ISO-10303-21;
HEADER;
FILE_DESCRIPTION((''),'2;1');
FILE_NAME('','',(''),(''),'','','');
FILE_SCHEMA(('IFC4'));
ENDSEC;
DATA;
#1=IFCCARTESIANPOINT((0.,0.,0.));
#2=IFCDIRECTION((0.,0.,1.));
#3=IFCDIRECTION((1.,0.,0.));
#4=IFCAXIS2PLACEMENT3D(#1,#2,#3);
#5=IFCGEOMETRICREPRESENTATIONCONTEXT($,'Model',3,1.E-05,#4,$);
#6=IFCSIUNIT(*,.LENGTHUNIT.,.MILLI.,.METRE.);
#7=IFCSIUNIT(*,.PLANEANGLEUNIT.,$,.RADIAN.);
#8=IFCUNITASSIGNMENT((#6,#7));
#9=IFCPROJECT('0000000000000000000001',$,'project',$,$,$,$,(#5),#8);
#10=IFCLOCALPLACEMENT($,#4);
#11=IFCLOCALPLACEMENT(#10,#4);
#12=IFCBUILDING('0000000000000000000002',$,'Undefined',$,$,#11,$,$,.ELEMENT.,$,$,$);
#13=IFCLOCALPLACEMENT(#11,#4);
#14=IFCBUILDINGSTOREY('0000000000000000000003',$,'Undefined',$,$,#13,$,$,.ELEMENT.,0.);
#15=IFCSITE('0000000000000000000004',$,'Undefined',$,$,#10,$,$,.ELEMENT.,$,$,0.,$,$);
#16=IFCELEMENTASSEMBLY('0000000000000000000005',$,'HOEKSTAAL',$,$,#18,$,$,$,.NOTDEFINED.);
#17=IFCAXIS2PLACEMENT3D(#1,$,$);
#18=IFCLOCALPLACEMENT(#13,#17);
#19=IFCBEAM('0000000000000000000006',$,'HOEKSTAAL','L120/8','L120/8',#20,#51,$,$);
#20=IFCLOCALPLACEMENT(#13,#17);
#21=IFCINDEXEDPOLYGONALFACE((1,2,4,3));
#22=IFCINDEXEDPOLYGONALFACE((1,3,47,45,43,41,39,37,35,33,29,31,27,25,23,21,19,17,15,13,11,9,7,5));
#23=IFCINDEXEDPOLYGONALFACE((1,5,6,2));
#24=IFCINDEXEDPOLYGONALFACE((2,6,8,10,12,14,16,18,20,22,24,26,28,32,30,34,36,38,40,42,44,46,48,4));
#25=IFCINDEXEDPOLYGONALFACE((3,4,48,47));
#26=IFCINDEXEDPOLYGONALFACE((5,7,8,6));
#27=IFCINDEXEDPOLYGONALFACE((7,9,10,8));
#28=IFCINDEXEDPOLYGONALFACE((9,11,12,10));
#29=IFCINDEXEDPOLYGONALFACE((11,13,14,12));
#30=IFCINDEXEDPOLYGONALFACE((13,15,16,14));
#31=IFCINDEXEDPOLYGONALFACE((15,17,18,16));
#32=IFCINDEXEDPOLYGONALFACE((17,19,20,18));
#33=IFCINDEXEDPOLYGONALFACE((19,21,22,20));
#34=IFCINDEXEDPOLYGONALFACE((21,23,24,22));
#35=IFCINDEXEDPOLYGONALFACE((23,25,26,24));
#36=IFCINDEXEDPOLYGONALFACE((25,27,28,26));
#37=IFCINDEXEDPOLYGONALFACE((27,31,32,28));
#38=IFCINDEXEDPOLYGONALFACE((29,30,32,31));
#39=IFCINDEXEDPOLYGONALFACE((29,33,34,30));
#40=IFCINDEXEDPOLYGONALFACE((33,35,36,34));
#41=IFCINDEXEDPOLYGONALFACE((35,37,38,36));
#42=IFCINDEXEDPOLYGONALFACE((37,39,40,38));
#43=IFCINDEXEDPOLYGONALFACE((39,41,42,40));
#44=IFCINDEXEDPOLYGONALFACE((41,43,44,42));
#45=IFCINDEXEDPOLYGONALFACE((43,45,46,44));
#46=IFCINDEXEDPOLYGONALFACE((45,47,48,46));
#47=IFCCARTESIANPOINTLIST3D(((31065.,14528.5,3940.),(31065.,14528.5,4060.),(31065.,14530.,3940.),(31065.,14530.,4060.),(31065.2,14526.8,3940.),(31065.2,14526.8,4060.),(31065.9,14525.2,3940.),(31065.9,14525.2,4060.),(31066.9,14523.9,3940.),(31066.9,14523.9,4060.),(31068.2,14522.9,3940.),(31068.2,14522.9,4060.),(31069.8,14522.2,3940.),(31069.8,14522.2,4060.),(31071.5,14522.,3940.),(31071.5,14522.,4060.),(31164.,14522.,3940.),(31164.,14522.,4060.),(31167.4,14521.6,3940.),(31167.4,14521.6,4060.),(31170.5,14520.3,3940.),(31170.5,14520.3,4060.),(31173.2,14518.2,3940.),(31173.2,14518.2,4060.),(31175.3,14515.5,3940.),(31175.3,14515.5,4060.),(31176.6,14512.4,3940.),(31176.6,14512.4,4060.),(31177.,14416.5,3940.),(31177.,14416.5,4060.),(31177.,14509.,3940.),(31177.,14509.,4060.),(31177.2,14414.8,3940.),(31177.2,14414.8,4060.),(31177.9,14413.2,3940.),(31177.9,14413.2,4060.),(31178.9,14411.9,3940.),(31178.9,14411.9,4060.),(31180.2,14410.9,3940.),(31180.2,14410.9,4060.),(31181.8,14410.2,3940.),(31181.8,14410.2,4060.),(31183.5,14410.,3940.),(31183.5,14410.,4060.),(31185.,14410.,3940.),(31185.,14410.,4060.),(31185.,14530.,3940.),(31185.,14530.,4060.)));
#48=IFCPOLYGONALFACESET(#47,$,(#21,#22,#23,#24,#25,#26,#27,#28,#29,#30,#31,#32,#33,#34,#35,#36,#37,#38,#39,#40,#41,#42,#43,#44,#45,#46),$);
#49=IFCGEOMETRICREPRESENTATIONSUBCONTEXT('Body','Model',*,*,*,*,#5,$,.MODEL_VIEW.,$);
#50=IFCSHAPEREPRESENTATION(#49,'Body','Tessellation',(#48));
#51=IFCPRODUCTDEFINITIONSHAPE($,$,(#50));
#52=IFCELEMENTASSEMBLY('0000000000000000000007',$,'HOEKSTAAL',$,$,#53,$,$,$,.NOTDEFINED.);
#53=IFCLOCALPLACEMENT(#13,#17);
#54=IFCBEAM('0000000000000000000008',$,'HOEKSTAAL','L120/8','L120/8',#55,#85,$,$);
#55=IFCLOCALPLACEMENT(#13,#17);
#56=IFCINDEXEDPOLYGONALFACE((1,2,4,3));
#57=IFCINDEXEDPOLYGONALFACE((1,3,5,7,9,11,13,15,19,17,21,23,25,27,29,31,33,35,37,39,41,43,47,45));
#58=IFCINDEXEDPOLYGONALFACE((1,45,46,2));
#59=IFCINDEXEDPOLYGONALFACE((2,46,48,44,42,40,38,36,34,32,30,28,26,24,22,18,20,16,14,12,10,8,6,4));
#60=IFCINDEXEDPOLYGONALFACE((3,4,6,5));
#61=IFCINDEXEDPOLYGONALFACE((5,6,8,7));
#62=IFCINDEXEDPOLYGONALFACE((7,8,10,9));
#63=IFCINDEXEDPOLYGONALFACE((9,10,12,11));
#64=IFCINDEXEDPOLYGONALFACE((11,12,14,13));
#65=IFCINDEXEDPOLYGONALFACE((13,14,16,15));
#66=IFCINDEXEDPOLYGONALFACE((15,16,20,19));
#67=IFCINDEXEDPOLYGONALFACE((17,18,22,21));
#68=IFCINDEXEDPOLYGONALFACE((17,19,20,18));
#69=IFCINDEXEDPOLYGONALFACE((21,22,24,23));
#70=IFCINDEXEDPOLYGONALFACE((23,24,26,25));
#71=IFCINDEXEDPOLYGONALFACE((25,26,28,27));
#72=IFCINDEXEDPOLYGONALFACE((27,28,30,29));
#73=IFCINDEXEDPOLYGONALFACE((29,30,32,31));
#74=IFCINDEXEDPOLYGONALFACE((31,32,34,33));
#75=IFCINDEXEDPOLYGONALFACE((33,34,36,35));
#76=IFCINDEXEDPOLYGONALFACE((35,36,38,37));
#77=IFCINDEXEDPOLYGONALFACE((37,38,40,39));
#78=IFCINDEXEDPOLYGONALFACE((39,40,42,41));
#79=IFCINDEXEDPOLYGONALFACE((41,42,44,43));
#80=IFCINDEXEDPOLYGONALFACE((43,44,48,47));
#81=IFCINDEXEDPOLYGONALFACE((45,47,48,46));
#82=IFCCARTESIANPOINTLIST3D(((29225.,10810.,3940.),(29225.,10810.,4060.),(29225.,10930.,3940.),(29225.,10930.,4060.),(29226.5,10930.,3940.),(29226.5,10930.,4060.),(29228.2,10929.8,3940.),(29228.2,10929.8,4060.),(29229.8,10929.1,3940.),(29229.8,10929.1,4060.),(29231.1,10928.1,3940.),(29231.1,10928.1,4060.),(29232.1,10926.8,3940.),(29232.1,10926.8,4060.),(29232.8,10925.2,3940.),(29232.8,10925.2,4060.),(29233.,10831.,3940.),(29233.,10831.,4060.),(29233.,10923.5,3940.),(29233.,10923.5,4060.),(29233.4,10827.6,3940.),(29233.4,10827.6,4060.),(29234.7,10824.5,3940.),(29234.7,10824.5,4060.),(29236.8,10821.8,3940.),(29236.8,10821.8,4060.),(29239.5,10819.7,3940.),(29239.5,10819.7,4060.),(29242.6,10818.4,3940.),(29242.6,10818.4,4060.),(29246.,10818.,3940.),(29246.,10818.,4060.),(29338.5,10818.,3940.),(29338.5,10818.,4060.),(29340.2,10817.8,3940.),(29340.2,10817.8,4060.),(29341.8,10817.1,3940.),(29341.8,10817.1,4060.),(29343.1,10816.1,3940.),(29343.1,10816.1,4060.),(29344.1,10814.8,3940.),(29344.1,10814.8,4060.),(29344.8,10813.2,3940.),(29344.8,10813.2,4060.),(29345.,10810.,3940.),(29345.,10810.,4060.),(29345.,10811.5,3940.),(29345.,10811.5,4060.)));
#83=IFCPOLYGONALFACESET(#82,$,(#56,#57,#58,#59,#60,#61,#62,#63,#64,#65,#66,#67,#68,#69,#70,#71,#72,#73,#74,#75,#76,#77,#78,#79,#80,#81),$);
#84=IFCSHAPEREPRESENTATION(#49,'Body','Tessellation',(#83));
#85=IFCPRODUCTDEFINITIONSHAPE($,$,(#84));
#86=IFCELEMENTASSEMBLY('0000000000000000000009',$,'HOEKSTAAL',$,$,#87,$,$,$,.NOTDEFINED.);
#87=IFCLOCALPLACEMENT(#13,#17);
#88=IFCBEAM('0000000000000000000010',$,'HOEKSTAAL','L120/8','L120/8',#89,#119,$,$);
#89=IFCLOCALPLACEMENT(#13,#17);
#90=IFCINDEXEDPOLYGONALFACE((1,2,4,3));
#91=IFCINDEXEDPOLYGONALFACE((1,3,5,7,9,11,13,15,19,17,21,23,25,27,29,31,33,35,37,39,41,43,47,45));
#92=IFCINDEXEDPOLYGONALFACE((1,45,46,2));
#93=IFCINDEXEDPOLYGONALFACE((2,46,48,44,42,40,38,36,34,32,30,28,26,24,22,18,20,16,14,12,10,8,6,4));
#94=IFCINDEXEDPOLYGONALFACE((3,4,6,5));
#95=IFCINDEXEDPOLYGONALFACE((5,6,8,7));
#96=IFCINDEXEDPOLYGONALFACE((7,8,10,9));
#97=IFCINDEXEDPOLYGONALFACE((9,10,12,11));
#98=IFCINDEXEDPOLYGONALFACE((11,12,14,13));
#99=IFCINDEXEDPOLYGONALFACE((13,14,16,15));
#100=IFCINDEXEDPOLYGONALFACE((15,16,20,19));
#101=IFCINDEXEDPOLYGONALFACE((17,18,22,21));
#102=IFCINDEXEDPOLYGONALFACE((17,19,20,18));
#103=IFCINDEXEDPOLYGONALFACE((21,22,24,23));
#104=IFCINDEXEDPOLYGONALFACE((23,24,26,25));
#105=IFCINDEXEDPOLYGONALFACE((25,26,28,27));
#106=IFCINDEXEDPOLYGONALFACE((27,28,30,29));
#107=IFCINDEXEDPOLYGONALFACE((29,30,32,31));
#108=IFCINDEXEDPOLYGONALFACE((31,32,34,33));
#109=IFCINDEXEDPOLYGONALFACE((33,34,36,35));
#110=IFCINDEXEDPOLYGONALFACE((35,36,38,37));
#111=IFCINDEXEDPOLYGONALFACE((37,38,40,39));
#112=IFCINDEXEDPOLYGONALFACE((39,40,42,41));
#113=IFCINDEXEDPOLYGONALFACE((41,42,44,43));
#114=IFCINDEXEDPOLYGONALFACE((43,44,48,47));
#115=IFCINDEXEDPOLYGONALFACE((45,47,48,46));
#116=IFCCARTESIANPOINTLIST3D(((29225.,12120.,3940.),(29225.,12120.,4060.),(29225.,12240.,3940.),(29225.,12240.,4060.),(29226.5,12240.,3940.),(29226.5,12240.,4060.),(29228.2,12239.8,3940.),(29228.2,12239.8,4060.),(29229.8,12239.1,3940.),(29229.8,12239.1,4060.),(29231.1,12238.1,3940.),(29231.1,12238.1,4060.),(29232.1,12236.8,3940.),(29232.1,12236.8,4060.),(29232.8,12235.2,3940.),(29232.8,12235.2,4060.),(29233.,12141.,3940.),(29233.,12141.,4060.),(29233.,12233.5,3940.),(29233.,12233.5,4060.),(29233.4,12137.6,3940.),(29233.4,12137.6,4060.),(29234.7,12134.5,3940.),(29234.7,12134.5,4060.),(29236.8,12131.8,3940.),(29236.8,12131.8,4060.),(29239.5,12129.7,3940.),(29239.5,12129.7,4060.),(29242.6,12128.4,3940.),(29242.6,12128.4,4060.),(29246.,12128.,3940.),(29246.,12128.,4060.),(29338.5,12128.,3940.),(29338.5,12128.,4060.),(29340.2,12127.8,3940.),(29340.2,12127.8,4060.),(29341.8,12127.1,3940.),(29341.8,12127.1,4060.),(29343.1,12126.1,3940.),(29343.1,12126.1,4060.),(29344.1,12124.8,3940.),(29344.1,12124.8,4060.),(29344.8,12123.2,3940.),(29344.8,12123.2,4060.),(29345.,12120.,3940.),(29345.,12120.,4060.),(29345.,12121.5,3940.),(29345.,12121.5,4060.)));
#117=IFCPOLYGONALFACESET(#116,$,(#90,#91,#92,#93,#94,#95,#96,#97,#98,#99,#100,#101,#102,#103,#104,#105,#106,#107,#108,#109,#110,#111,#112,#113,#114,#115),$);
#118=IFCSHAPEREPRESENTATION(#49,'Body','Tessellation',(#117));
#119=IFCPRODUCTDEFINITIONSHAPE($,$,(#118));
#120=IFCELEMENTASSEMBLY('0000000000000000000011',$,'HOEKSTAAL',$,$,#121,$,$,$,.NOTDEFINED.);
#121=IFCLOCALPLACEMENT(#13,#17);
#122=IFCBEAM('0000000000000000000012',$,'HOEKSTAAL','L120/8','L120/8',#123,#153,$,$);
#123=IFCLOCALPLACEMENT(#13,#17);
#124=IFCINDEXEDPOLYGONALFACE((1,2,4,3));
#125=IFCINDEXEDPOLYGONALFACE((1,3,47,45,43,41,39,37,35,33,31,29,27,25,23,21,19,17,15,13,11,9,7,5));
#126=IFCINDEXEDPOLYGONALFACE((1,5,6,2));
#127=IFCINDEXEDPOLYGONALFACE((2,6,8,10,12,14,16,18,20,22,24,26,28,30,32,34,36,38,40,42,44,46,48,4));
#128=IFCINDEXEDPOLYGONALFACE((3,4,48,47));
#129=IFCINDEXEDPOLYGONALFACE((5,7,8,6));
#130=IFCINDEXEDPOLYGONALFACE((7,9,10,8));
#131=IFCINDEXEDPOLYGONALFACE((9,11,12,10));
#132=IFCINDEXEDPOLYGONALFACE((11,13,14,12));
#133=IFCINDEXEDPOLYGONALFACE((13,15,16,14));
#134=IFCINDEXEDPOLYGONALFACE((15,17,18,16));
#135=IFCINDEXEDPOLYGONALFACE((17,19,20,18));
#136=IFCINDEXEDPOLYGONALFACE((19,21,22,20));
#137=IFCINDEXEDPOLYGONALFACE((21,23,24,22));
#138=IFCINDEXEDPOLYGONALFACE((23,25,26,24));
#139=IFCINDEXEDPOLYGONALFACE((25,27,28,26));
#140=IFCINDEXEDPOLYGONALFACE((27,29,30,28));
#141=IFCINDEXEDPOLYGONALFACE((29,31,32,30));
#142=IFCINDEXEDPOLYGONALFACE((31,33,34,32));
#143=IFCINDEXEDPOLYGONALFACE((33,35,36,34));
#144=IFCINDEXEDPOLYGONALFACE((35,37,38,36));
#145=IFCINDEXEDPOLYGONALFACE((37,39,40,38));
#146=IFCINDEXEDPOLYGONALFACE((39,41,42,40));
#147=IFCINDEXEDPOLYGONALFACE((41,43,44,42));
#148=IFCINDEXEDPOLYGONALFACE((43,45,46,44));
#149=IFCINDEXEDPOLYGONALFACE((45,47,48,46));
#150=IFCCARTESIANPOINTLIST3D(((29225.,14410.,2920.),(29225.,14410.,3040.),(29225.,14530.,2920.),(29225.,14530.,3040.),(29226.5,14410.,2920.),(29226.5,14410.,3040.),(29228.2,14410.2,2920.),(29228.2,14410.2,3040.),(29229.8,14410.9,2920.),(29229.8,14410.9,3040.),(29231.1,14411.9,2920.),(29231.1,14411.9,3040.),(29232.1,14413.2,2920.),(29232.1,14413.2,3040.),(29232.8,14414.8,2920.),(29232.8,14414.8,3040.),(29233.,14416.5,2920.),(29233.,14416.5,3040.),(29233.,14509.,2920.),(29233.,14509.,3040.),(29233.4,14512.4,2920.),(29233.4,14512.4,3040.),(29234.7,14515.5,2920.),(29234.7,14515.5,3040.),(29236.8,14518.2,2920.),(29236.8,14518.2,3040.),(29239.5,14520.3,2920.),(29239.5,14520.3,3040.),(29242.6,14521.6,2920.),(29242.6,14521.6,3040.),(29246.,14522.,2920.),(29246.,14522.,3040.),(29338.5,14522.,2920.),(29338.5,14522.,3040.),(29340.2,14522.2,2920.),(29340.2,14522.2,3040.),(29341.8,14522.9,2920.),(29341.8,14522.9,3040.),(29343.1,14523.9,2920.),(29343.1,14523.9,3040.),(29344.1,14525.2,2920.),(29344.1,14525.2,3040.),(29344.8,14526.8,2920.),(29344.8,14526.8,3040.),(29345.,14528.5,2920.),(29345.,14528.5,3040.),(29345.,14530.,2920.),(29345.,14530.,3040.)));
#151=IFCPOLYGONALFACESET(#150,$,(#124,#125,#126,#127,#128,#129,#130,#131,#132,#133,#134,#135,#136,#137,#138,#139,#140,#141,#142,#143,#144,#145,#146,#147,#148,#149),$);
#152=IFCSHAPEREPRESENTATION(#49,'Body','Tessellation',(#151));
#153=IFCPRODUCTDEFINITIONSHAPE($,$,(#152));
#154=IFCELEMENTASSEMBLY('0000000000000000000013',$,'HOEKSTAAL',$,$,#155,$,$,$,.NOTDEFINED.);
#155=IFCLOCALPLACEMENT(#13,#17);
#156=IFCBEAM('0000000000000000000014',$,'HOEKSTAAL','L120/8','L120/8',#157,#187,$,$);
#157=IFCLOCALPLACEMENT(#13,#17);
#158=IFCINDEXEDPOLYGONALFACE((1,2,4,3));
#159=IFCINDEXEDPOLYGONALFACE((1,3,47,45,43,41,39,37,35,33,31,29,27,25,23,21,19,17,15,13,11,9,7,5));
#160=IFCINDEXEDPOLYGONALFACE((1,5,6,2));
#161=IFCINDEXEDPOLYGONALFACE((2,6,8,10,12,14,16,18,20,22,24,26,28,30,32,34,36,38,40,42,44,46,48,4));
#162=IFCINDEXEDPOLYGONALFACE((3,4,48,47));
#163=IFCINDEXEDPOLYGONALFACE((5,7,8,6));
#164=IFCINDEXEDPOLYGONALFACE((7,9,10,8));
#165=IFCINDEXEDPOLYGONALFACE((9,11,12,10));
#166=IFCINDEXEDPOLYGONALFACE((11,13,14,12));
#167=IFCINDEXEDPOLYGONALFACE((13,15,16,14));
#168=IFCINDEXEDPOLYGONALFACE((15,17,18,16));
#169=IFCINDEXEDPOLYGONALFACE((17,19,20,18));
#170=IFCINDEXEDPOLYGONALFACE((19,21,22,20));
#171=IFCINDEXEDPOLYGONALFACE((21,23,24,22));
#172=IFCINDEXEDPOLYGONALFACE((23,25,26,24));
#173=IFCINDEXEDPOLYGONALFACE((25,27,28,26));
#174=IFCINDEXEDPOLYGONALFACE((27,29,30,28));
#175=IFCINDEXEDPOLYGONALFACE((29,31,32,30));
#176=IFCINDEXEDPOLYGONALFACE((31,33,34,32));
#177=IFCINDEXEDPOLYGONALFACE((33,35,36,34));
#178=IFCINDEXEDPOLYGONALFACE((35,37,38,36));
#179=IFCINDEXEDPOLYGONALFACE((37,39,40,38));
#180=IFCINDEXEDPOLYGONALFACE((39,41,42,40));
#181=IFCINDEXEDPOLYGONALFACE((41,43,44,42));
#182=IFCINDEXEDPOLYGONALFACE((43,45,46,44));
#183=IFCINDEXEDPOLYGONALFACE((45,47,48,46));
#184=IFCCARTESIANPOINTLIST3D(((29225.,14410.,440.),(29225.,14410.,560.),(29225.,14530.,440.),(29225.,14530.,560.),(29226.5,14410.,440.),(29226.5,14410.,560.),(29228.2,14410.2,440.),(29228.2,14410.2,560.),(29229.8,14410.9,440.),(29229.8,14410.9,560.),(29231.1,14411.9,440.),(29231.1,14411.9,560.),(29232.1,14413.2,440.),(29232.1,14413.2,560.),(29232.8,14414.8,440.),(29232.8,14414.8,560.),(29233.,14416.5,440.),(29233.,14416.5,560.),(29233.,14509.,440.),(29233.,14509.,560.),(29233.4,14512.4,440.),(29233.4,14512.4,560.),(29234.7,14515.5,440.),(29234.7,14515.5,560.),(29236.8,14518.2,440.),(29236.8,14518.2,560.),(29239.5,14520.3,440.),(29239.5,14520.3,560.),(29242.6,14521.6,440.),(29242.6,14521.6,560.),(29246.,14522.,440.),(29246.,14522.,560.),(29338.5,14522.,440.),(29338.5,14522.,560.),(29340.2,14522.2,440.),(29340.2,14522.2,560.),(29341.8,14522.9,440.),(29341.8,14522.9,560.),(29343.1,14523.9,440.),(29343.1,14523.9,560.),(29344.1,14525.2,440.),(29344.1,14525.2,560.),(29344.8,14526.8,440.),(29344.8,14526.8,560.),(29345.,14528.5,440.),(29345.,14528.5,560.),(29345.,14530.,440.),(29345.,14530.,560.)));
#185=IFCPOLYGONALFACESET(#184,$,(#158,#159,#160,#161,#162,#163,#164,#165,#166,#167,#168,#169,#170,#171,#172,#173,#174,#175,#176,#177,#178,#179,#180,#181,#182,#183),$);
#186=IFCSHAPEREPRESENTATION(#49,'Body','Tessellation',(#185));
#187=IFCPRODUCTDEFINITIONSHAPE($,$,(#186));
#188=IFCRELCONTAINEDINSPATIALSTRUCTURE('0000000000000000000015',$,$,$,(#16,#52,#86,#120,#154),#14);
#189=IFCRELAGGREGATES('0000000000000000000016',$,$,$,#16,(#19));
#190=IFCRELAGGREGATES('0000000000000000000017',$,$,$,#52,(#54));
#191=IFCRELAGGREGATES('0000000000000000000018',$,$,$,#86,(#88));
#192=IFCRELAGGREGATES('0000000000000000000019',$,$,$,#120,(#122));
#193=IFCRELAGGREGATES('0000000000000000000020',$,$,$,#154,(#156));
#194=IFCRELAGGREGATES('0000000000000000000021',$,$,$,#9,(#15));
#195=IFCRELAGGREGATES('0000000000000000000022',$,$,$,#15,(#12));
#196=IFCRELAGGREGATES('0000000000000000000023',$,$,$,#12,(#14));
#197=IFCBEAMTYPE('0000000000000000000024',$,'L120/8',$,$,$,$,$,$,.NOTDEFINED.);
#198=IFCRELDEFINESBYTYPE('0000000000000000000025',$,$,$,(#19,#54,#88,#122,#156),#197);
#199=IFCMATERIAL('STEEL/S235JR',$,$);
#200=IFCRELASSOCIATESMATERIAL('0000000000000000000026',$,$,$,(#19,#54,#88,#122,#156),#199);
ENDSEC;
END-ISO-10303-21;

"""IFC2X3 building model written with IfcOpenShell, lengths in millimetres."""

from ifc_helpers import new_model, si_unit, frame, origin_with_axes, origin_2d_with_axis, place, context, subcontext, project, spatial, l_section, extrude, material, type_object, element, aggregate, save


model = new_model("IFC2X3")

# Units and contexts
model_context = context("Model", 3, precision=1e-05, world=origin_with_axes())
body_context = subcontext(model_context, "Body", "Model", "MODEL_VIEW")
ifc_project = project(units=[si_unit("LENGTHUNIT", "METRE", prefix="MILLI"), si_unit("PLANEANGLEUNIT", "RADIAN")], contexts=[model_context])

# Site, building, storey
site_placement = place(None, origin_with_axes())
site = spatial("IfcSite", under=ifc_project, at=site_placement, Name="Undefined", CompositionType="ELEMENT", RefElevation=0.0)
building_placement = place(site_placement, origin_with_axes())
building = spatial("IfcBuilding", under=site, at=building_placement, Name="Undefined", CompositionType="ELEMENT")
storey_placement = place(building_placement, origin_with_axes())
storey = spatial("IfcBuildingStorey", under=building, at=storey_placement, Name="Undefined", CompositionType="ELEMENT", Elevation=0.0)

# Element assemblies, beams
assembly_1_placement = place(storey_placement, origin_with_axes())
assembly_1 = element("IfcElementAssembly", 1, at=assembly_1_placement, inside=storey, Name="HOEKSTAAL", PredefinedType="NOTDEFINED")
ifc_material_1 = material(Name="STEEL/S235JR")
beam_type_1 = type_object("IfcBeamType", Name="L120/8", PredefinedType="NOTDEFINED")
beam_1_placement = place(assembly_1_placement, frame((31125.0, 14470.0, 3940.0), z_axis=(-1.0, 0.0, 0.0), x_axis=(0.0, 0.0, 1.0)))
beam_1 = element("IfcBeam", 2, at=beam_1_placement, type_object=beam_type_1, material=ifc_material_1, Name="HOEKSTAAL", Description="L120/8", ObjectType="L120/8", context=body_context, shape_type="SweptSolid", body=[
    extrude(l_section(Depth=120.0, Width=120.0, Thickness=8.0, FilletRadius=13.0, EdgeRadius=6.5, at=origin_2d_with_axis()), frame((120.0, 0.0, 0.0), z_axis=(-1.0, 0.0, 0.0), x_axis=(0.0, -1.0, 0.0)), (0.0, 0.0, 1.0), 120.0),
])
aggregate(assembly_1, [beam_1])
assembly_2_placement = place(storey_placement, origin_with_axes())
assembly_2 = element("IfcElementAssembly", 3, at=assembly_2_placement, inside=storey, Name="HOEKSTAAL", PredefinedType="NOTDEFINED")
beam_2_placement = place(assembly_2_placement, frame((29285.0, 10870.0, 3940.0), z_axis=(1.0, 0.0, 0.0), x_axis=(0.0, 0.0, 1.0)))
beam_2 = element("IfcBeam", 4, at=beam_2_placement, type_object=beam_type_1, material=ifc_material_1, Name="HOEKSTAAL", Description="L120/8", ObjectType="L120/8", context=body_context, shape_type="SweptSolid", body=[
    extrude(l_section(Depth=120.0, Width=120.0, Thickness=8.0, FilletRadius=13.0, EdgeRadius=6.5, at=origin_2d_with_axis()), frame((120.0, 0.0, 0.0), z_axis=(-1.0, 0.0, 0.0), x_axis=(0.0, -1.0, 0.0)), (0.0, 0.0, 1.0), 120.0),
])
aggregate(assembly_2, [beam_2])
assembly_3_placement = place(storey_placement, origin_with_axes())
assembly_3 = element("IfcElementAssembly", 5, at=assembly_3_placement, inside=storey, Name="HOEKSTAAL", PredefinedType="NOTDEFINED")
beam_3_placement = place(assembly_3_placement, frame((29285.0, 12180.0, 3940.0), z_axis=(1.0, 0.0, 0.0), x_axis=(0.0, 0.0, 1.0)))
beam_3 = element("IfcBeam", 6, at=beam_3_placement, type_object=beam_type_1, material=ifc_material_1, Name="HOEKSTAAL", Description="L120/8", ObjectType="L120/8", context=body_context, shape_type="SweptSolid", body=[
    extrude(l_section(Depth=120.0, Width=120.0, Thickness=8.0, FilletRadius=13.0, EdgeRadius=6.5, at=origin_2d_with_axis()), frame((120.0, 0.0, 0.0), z_axis=(-1.0, 0.0, 0.0), x_axis=(0.0, -1.0, 0.0)), (0.0, 0.0, 1.0), 120.0),
])
aggregate(assembly_3, [beam_3])
assembly_4_placement = place(storey_placement, origin_with_axes())
assembly_4 = element("IfcElementAssembly", 7, at=assembly_4_placement, inside=storey, Name="HOEKSTAAL", PredefinedType="NOTDEFINED")
beam_4_placement = place(assembly_4_placement, frame((29285.0, 14470.0, 3040.0), z_axis=(1.0, 0.0, 0.0), x_axis=(0.0, 0.0, -1.0)))
beam_4 = element("IfcBeam", 8, at=beam_4_placement, type_object=beam_type_1, material=ifc_material_1, Name="HOEKSTAAL", Description="L120/8", ObjectType="L120/8", context=body_context, shape_type="SweptSolid", body=[
    extrude(l_section(Depth=120.0, Width=120.0, Thickness=8.0, FilletRadius=13.0, EdgeRadius=6.5, at=origin_2d_with_axis()), frame((120.0, 0.0, 0.0), z_axis=(-1.0, 0.0, 0.0), x_axis=(0.0, -1.0, 0.0)), (0.0, 0.0, 1.0), 120.0),
])
aggregate(assembly_4, [beam_4])
assembly_5_placement = place(storey_placement, origin_with_axes())
assembly_5 = element("IfcElementAssembly", 9, at=assembly_5_placement, inside=storey, Name="HOEKSTAAL", PredefinedType="NOTDEFINED")
beam_5_placement = place(assembly_5_placement, frame((29285.0, 14470.0, 560.0), z_axis=(1.0, 0.0, 0.0), x_axis=(0.0, 0.0, -1.0)))
beam_5 = element("IfcBeam", 10, at=beam_5_placement, type_object=beam_type_1, material=ifc_material_1, Name="HOEKSTAAL", Description="L120/8", ObjectType="L120/8", context=body_context, shape_type="SweptSolid", body=[
    extrude(l_section(Depth=120.0, Width=120.0, Thickness=8.0, FilletRadius=13.0, EdgeRadius=6.5, at=origin_2d_with_axis()), frame((120.0, 0.0, 0.0), z_axis=(-1.0, 0.0, 0.0), x_axis=(0.0, -1.0, 0.0)), (0.0, 0.0, 1.0), 120.0),
])
aggregate(assembly_5, [beam_5])

save(model, "model.ifc")
